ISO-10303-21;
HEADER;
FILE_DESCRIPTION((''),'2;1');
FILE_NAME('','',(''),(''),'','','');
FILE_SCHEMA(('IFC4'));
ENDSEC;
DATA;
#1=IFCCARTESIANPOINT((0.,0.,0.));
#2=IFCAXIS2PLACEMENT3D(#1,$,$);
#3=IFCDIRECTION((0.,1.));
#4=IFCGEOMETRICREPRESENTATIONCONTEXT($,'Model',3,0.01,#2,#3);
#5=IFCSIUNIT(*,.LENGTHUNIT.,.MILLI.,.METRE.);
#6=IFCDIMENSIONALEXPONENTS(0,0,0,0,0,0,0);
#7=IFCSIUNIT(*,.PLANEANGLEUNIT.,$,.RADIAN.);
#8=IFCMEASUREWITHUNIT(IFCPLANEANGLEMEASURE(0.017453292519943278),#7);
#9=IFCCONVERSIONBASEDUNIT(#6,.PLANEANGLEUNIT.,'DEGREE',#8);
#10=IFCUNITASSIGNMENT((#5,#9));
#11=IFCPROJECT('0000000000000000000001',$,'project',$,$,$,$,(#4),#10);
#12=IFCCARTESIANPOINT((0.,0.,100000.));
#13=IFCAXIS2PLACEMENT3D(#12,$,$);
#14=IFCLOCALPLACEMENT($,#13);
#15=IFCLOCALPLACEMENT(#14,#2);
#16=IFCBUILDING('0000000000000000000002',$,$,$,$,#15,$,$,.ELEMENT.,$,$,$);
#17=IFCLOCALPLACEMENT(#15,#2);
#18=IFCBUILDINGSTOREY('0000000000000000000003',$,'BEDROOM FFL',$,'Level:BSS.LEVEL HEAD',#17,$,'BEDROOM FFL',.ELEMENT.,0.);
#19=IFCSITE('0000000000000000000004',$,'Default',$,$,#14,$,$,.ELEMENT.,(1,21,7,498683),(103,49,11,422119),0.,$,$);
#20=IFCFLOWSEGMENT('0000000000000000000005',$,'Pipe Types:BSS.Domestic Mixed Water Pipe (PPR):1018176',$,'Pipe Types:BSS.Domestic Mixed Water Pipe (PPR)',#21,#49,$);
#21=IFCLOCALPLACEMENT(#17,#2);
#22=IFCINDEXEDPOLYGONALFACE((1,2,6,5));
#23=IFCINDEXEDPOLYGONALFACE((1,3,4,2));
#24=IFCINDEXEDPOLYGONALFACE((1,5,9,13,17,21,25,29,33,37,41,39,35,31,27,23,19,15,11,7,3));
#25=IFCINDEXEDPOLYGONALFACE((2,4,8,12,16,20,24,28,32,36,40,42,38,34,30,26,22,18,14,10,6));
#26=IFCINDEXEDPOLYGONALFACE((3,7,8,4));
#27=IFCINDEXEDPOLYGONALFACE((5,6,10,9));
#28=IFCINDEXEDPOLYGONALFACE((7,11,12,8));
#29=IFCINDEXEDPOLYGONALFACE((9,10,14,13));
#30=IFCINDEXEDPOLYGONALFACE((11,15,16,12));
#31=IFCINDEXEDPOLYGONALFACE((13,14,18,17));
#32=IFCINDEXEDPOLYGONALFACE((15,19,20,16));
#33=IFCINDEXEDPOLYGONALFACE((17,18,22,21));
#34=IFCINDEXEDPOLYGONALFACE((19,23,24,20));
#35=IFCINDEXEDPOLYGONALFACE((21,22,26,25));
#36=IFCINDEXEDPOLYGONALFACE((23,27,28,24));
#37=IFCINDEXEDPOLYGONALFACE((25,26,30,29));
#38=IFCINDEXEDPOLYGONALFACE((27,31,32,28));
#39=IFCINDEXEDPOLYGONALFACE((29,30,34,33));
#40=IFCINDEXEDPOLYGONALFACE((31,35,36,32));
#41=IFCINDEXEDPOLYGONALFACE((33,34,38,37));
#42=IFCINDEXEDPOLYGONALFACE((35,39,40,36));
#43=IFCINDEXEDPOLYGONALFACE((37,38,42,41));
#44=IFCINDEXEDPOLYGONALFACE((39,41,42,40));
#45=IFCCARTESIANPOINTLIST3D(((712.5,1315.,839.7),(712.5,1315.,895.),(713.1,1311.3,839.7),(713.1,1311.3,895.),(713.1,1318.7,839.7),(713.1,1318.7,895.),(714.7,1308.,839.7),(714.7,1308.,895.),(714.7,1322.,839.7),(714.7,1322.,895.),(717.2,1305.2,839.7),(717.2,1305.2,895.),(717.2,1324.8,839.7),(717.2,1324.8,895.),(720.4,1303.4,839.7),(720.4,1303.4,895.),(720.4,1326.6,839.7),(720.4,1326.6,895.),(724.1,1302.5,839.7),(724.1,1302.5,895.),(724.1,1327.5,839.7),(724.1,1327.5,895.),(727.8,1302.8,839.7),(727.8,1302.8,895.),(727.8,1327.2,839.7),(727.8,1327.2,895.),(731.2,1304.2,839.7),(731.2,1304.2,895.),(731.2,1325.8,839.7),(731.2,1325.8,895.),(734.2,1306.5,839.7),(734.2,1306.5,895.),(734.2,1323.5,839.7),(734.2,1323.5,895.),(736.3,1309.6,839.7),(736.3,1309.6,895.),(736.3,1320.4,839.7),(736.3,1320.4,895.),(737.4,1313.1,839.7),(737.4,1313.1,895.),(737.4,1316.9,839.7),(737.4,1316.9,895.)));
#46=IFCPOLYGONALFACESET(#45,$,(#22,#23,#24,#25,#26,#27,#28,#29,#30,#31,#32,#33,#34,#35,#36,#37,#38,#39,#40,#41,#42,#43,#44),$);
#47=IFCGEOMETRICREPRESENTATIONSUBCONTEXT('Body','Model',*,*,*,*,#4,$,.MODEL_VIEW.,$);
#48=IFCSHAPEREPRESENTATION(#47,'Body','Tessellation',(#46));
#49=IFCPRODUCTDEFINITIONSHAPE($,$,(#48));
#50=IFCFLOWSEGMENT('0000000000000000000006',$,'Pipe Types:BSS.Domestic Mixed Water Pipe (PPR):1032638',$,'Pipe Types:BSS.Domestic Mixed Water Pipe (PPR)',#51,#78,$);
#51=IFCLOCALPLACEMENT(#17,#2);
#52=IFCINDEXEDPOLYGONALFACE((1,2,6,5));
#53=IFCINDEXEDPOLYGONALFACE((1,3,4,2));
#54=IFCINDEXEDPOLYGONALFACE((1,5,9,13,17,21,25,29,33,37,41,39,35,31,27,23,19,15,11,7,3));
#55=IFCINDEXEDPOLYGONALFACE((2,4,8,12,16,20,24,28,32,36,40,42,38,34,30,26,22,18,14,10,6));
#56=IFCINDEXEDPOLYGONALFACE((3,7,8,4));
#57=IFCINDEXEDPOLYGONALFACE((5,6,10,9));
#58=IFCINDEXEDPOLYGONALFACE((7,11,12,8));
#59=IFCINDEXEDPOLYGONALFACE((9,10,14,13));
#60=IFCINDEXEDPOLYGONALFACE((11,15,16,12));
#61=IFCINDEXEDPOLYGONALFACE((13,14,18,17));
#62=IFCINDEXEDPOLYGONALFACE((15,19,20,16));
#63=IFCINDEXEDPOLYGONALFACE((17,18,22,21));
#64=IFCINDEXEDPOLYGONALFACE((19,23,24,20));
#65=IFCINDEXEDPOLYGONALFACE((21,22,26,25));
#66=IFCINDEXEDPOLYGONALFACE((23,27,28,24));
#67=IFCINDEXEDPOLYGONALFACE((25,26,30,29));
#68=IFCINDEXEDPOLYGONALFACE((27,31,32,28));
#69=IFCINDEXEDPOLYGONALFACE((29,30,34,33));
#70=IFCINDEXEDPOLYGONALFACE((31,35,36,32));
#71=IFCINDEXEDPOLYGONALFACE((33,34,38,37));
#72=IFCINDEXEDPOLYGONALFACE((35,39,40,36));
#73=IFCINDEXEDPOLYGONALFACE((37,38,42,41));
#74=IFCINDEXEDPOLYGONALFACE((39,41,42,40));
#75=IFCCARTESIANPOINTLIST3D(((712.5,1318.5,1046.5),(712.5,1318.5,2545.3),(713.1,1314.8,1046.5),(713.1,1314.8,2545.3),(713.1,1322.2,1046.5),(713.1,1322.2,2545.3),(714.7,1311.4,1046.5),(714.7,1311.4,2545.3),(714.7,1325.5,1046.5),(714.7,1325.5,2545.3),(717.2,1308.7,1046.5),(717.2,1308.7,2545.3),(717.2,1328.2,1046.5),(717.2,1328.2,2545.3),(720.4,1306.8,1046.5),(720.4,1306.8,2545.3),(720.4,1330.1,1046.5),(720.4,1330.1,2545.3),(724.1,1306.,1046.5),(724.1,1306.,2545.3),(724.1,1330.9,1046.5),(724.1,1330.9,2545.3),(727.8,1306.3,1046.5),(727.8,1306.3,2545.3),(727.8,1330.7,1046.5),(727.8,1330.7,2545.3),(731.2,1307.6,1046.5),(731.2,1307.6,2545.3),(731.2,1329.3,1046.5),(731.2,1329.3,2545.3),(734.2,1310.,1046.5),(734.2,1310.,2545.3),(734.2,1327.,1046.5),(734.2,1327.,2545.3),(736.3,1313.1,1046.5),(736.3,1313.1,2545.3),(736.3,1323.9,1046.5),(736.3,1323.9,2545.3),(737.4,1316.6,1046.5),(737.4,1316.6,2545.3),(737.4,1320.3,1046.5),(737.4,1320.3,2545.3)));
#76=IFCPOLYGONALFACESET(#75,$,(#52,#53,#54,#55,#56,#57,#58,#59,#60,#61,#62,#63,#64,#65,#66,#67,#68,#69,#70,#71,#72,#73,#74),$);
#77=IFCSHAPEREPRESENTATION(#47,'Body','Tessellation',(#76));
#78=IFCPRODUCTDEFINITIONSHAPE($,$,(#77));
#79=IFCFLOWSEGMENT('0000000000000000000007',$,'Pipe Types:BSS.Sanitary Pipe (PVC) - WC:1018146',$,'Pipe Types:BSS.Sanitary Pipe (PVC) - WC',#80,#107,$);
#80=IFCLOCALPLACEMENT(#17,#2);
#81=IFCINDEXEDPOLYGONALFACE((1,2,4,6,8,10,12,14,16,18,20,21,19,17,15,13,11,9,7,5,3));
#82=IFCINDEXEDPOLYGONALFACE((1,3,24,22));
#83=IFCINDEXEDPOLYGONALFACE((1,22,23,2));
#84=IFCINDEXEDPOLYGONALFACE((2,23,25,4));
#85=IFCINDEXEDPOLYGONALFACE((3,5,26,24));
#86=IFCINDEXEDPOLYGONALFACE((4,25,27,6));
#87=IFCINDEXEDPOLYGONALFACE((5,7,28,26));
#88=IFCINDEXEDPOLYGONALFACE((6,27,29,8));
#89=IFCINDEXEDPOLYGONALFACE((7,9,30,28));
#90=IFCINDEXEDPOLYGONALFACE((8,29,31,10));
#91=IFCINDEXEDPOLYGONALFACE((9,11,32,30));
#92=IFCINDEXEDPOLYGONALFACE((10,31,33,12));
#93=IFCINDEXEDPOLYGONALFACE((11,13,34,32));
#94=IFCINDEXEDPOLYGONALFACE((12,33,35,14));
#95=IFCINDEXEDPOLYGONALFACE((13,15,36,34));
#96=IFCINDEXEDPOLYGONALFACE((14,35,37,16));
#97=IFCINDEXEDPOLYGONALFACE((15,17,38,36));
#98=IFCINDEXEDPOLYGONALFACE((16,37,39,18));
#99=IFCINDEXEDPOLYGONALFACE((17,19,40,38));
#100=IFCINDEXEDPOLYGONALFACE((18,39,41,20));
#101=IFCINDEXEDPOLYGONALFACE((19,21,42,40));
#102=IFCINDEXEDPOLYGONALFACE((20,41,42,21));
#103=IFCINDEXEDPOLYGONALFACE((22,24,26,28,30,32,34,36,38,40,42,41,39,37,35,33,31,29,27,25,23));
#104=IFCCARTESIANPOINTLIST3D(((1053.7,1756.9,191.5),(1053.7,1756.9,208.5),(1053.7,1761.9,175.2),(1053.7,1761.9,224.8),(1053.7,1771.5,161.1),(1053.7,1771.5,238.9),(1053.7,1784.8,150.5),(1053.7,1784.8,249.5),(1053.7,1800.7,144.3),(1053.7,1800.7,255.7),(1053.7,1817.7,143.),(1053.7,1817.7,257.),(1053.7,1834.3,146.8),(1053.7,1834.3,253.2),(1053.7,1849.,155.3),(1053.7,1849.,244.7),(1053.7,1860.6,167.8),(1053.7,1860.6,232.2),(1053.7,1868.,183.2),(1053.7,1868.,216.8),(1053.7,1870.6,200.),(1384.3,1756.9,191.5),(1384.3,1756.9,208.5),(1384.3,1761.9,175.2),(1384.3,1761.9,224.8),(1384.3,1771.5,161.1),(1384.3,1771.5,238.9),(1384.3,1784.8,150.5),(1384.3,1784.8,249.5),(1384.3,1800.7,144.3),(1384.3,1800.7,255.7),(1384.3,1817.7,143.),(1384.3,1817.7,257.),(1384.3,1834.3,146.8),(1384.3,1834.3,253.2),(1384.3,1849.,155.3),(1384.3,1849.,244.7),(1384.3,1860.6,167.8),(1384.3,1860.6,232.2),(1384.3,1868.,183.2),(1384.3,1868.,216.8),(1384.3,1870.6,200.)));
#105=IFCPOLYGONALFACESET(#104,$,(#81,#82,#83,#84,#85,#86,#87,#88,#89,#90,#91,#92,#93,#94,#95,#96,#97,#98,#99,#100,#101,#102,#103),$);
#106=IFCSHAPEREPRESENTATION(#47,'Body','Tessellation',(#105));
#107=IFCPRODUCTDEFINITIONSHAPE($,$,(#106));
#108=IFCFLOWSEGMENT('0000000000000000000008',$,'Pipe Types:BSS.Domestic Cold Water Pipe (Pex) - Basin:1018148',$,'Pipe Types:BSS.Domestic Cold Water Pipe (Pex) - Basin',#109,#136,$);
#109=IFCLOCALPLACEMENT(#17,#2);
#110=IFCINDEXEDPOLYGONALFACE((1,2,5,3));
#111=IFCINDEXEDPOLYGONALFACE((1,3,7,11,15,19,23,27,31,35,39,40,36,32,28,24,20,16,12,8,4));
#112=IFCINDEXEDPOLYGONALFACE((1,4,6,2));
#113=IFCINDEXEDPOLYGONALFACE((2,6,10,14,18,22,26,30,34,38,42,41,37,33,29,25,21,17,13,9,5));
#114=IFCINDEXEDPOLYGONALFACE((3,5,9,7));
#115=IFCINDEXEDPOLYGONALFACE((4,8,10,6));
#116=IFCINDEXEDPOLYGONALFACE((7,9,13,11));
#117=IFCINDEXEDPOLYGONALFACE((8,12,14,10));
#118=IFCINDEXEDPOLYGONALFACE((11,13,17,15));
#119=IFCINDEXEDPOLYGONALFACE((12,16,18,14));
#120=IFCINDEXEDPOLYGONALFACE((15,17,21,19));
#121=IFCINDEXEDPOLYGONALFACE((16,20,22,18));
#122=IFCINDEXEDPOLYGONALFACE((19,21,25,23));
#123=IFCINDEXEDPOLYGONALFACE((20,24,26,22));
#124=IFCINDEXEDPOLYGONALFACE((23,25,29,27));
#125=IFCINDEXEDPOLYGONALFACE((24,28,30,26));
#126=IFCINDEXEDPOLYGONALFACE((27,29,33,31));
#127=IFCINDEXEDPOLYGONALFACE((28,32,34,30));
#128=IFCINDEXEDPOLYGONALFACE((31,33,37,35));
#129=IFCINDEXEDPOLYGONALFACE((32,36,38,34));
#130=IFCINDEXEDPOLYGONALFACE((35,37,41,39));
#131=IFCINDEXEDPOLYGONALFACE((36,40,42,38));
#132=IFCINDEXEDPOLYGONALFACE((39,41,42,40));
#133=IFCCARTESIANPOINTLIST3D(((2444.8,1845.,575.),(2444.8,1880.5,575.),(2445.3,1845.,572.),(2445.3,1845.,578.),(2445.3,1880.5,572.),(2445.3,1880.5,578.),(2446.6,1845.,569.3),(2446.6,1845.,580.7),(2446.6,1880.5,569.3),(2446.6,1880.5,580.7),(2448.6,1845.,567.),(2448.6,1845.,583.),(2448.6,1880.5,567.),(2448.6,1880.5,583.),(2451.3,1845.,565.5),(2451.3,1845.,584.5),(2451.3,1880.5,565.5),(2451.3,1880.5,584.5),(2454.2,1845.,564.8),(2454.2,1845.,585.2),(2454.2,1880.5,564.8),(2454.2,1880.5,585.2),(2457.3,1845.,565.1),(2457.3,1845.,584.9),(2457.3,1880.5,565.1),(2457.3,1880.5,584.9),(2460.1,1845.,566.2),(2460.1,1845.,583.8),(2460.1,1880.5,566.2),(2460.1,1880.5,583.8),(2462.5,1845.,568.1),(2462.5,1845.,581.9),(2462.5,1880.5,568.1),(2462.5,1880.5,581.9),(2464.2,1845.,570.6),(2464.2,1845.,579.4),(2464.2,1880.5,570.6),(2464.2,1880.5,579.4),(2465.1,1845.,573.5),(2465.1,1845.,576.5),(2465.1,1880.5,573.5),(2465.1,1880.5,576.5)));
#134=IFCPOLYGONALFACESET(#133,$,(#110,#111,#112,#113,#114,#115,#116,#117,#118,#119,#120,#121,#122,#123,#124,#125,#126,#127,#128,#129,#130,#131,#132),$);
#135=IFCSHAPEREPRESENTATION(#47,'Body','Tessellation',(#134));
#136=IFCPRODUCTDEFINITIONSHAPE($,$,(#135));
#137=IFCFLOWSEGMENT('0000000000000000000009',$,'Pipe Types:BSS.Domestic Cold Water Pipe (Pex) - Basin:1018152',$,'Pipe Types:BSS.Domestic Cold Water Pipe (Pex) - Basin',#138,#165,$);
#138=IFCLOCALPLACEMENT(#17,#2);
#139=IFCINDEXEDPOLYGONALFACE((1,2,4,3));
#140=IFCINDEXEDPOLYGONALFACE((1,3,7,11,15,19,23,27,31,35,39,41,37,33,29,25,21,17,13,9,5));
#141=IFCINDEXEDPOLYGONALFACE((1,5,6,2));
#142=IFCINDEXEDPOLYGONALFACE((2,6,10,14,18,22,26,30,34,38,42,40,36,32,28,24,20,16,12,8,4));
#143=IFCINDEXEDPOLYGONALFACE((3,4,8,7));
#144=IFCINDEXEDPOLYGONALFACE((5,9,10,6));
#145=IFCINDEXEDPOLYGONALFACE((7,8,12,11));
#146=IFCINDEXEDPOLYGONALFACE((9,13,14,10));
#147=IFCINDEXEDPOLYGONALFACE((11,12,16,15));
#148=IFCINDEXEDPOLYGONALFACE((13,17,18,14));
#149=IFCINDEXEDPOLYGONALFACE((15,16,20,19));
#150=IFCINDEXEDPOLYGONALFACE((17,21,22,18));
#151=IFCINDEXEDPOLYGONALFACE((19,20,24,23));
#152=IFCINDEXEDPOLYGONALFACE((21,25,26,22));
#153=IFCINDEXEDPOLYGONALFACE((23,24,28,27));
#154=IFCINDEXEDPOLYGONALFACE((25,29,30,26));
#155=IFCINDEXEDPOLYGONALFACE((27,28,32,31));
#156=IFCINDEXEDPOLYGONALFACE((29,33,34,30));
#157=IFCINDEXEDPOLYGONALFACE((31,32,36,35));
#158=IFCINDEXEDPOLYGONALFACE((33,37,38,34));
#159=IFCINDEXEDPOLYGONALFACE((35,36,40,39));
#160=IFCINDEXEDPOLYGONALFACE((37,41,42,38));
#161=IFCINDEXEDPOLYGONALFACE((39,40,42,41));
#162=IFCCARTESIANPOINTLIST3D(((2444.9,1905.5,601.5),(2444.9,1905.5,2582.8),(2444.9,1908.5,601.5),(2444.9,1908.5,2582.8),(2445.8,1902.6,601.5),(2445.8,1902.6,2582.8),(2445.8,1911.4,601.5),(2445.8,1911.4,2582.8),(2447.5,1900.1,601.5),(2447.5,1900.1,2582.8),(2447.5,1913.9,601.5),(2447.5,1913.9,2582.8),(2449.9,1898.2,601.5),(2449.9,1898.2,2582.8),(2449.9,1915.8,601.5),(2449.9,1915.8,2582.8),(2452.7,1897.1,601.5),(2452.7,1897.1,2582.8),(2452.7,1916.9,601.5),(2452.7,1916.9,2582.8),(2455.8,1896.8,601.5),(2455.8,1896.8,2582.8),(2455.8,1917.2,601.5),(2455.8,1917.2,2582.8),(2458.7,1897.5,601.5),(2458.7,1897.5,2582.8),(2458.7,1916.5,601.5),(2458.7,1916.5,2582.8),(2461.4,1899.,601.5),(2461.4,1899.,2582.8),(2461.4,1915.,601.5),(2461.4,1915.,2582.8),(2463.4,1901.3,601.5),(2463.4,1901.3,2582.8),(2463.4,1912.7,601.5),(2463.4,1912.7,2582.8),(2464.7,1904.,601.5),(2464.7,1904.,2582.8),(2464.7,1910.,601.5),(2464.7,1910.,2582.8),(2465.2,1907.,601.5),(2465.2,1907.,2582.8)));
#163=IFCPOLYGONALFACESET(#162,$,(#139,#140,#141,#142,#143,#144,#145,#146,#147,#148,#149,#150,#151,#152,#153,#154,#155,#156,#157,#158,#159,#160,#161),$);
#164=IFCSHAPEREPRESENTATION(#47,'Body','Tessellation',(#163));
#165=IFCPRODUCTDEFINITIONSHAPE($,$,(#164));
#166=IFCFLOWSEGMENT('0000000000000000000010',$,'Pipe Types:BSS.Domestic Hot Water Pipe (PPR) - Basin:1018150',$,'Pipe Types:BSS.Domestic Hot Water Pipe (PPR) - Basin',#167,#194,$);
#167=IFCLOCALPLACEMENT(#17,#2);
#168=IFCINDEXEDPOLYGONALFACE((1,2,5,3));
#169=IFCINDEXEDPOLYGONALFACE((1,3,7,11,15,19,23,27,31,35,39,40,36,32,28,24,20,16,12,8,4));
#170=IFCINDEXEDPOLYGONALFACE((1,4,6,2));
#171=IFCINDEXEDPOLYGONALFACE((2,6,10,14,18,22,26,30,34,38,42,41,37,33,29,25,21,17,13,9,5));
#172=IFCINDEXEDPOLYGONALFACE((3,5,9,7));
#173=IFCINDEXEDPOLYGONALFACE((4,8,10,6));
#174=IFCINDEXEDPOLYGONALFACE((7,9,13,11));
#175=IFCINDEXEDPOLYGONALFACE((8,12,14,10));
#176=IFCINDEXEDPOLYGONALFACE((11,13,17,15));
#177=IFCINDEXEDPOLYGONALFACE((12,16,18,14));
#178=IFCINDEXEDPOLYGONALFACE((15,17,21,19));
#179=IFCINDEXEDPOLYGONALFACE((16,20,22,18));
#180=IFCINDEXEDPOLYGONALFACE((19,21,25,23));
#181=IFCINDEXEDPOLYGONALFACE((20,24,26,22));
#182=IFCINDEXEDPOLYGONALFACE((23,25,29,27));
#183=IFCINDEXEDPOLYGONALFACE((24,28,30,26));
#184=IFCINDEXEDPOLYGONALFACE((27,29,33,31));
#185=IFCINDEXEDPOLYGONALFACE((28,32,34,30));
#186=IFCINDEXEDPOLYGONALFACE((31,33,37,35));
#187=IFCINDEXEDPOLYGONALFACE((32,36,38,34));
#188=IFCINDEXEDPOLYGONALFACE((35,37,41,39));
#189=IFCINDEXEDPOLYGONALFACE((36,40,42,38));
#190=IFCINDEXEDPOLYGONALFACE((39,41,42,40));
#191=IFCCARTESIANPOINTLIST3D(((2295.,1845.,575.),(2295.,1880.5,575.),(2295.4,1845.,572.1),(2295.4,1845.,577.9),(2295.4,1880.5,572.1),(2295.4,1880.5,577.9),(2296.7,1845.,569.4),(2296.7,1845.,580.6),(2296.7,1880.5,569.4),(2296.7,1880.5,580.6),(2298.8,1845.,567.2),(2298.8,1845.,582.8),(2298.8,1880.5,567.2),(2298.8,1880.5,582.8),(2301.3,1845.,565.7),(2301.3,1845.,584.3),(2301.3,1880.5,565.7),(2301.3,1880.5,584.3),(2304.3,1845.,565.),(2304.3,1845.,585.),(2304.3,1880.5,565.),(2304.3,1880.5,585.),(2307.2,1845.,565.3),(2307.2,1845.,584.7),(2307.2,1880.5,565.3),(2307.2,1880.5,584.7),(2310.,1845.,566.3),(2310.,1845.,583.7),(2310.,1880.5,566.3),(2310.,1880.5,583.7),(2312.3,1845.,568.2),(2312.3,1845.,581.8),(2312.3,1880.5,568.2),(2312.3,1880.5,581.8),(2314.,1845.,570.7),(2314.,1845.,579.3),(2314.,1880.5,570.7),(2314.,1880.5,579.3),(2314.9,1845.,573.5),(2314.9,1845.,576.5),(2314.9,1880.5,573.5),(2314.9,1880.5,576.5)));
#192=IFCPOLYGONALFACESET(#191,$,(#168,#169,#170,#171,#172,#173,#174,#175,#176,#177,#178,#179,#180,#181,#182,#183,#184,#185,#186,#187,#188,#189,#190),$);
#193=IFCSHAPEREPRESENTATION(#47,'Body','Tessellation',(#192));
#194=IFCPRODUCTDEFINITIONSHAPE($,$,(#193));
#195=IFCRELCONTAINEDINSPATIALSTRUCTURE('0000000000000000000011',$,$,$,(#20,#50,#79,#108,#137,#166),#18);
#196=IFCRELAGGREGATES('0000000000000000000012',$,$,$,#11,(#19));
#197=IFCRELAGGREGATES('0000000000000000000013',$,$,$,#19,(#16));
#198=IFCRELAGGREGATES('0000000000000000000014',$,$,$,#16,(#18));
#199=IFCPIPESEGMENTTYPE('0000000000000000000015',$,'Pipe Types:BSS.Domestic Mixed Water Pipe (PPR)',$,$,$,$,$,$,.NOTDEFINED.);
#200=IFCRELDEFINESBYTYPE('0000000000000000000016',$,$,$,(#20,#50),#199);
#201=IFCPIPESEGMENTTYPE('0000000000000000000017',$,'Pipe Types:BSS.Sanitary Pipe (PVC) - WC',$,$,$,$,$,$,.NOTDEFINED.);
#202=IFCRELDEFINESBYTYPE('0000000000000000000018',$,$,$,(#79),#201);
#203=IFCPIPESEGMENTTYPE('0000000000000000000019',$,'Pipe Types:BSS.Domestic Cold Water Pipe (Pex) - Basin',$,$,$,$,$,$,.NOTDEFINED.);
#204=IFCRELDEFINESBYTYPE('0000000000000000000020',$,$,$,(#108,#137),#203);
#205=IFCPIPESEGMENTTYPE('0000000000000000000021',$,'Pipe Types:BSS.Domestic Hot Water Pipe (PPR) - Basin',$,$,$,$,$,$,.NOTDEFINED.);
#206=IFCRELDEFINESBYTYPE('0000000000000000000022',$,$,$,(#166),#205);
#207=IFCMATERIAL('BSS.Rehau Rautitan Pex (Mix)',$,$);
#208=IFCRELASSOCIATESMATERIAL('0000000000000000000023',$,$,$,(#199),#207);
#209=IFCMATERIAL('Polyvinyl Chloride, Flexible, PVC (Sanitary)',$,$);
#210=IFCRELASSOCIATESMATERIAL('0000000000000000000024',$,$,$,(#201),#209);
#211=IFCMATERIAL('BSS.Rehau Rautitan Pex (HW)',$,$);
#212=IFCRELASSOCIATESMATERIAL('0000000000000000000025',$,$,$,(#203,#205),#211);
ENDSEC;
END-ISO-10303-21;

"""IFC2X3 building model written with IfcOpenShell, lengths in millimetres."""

from ifc_helpers import new_model, entity, si_unit, converted_unit, direction, frame, frame_2d, origin, origin_2d_with_axis, place, context, subcontext, project, spatial, circle, extrude, material, type_object, element, save


model = new_model("IFC2X3")

# Units and contexts
model_context = context("Model", 3, precision=0.01, world=origin(), true_north=direction((0.0, 1.0)))
body_context = subcontext(model_context, "Body", "Model", "MODEL_VIEW")
ifc_project = project(units=[si_unit("LENGTHUNIT", "METRE", prefix="MILLI"), converted_unit("PLANEANGLEUNIT", "DEGREE", entity("IfcPlaneAngleMeasure", 0.017453292519943278), si_unit("PLANEANGLEUNIT", "RADIAN"), dimensions=[0, 0, 0, 0, 0, 0, 0])], contexts=[model_context])

# Site, building, storey
site_placement = place(None, frame((0.0, 0.0, 100000.0)))
site = spatial("IfcSite", under=ifc_project, at=site_placement, Name="Default", CompositionType="ELEMENT", RefLatitude=(1, 21, 7, 498683), RefLongitude=(103, 49, 11, 422119), RefElevation=0.0)
building_placement = place(site_placement, origin())
building = spatial("IfcBuilding", under=site, at=building_placement, CompositionType="ELEMENT")
storey_placement = place(building_placement, origin())
storey = spatial("IfcBuildingStorey", under=building, at=storey_placement, Name="BEDROOM FFL", ObjectType="Level:BSS.LEVEL HEAD", LongName="BEDROOM FFL", CompositionType="ELEMENT", Elevation=0.0)

# Flow segments
ifc_material_1 = material(Name="Polyvinyl Chloride, Flexible, PVC (Sanitary)")
ifc_material_2 = material(Name="BSS.Rehau Rautitan Pex (Mix)")
pipe_segment_type_1 = type_object("IfcPipeSegmentType", Name="Pipe Types:BSS.Domestic Mixed Water Pipe (PPR)", PredefinedType="NOTDEFINED", material=ifc_material_2)
flow_segment_1_placement = place(storey_placement, origin())
element("IfcFlowSegment", 1, at=flow_segment_1_placement, inside=storey, type_object=pipe_segment_type_1, Name="Pipe Types:BSS.Domestic Mixed Water Pipe (PPR):1018176", ObjectType="Pipe Types:BSS.Domestic Mixed Water Pipe (PPR)", context=body_context, shape_type="SweptSolid", body=[
    extrude(circle(Radius=12.5, at=origin_2d_with_axis()), frame((725.0, 1315.0, 839.7), z_axis=(0.0, 0.0, 1.0), x_axis=(-1.0, 0.0, 0.0)), (0.0, 0.0, 1.0), 55.3),
])
flow_segment_2_placement = place(storey_placement, origin())
element("IfcFlowSegment", 2, at=flow_segment_2_placement, inside=storey, type_object=pipe_segment_type_1, Name="Pipe Types:BSS.Domestic Mixed Water Pipe (PPR):1032638", ObjectType="Pipe Types:BSS.Domestic Mixed Water Pipe (PPR)", context=body_context, shape_type="SweptSolid", body=[
    extrude(circle(Radius=12.5, at=frame_2d((0.0, 0.0), x_axis=(1.0, 0.0))), frame((725.0, 1318.5, 1046.5), z_axis=(0.0, 0.0, 1.0), x_axis=(-1.0, 0.0, 0.0)), (0.0, 0.0, 1.0), 1498.8),
])
pipe_segment_type_2 = type_object("IfcPipeSegmentType", Name="Pipe Types:BSS.Sanitary Pipe (PVC) - WC", PredefinedType="NOTDEFINED", material=ifc_material_1)
flow_segment_3_placement = place(storey_placement, origin())
element("IfcFlowSegment", 3, at=flow_segment_3_placement, inside=storey, type_object=pipe_segment_type_2, Name="Pipe Types:BSS.Sanitary Pipe (PVC) - WC:1018146", ObjectType="Pipe Types:BSS.Sanitary Pipe (PVC) - WC", context=body_context, shape_type="SweptSolid", body=[
    extrude(circle(Radius=57.2, at=frame_2d((0.0, 0.0), x_axis=(1.0, 0.0))), frame((1053.7, 1813.4, 200.0), z_axis=(1.0, 0.0, 0.0), x_axis=(0.0, 1.0, 0.0)), (0.0, 0.0, 1.0), 330.6),
])
ifc_material_3 = material(Name="BSS.Rehau Rautitan Pex (HW)")
pipe_segment_type_3 = type_object("IfcPipeSegmentType", Name="Pipe Types:BSS.Domestic Cold Water Pipe (Pex) - Basin", PredefinedType="NOTDEFINED", material=ifc_material_3)
flow_segment_4_placement = place(storey_placement, origin())
element("IfcFlowSegment", 4, at=flow_segment_4_placement, inside=storey, type_object=pipe_segment_type_3, Name="Pipe Types:BSS.Domestic Cold Water Pipe (Pex) - Basin:1018148", ObjectType="Pipe Types:BSS.Domestic Cold Water Pipe (Pex) - Basin", context=body_context, shape_type="SweptSolid", body=[
    extrude(circle(Radius=10.2, at=frame_2d((0.0, 0.0), x_axis=(1.0, 0.0))), frame((2455.0, 1845.0, 575.0), z_axis=(0.0, 1.0, 0.0), x_axis=(-1.0, 0.0, 0.0)), (0.0, 0.0, 1.0), 35.5),
])
flow_segment_5_placement = place(storey_placement, origin())
element("IfcFlowSegment", 5, at=flow_segment_5_placement, inside=storey, type_object=pipe_segment_type_3, Name="Pipe Types:BSS.Domestic Cold Water Pipe (Pex) - Basin:1018152", ObjectType="Pipe Types:BSS.Domestic Cold Water Pipe (Pex) - Basin", context=body_context, shape_type="SweptSolid", body=[
    extrude(circle(Radius=10.2, at=frame_2d((0.0, 0.0), x_axis=(1.0, 0.0))), frame((2455.0, 1907.0, 601.5)), (0.0, 0.0, 1.0), 1981.3),
])
pipe_segment_type_4 = type_object("IfcPipeSegmentType", Name="Pipe Types:BSS.Domestic Hot Water Pipe (PPR) - Basin", PredefinedType="NOTDEFINED", material=ifc_material_3)
flow_segment_6_placement = place(storey_placement, origin())
element("IfcFlowSegment", 6, at=flow_segment_6_placement, inside=storey, type_object=pipe_segment_type_4, Name="Pipe Types:BSS.Domestic Hot Water Pipe (PPR) - Basin:1018150", ObjectType="Pipe Types:BSS.Domestic Hot Water Pipe (PPR) - Basin", context=body_context, shape_type="SweptSolid", body=[
    extrude(circle(Radius=10.0, at=origin_2d_with_axis()), frame((2305.0, 1845.0, 575.0), z_axis=(0.000001, 1.0, 0.0), x_axis=(-1.0, 0.000001, 0.0)), (0.0, 0.0, 1.0), 35.5),
])

save(model, "model.ifc")
